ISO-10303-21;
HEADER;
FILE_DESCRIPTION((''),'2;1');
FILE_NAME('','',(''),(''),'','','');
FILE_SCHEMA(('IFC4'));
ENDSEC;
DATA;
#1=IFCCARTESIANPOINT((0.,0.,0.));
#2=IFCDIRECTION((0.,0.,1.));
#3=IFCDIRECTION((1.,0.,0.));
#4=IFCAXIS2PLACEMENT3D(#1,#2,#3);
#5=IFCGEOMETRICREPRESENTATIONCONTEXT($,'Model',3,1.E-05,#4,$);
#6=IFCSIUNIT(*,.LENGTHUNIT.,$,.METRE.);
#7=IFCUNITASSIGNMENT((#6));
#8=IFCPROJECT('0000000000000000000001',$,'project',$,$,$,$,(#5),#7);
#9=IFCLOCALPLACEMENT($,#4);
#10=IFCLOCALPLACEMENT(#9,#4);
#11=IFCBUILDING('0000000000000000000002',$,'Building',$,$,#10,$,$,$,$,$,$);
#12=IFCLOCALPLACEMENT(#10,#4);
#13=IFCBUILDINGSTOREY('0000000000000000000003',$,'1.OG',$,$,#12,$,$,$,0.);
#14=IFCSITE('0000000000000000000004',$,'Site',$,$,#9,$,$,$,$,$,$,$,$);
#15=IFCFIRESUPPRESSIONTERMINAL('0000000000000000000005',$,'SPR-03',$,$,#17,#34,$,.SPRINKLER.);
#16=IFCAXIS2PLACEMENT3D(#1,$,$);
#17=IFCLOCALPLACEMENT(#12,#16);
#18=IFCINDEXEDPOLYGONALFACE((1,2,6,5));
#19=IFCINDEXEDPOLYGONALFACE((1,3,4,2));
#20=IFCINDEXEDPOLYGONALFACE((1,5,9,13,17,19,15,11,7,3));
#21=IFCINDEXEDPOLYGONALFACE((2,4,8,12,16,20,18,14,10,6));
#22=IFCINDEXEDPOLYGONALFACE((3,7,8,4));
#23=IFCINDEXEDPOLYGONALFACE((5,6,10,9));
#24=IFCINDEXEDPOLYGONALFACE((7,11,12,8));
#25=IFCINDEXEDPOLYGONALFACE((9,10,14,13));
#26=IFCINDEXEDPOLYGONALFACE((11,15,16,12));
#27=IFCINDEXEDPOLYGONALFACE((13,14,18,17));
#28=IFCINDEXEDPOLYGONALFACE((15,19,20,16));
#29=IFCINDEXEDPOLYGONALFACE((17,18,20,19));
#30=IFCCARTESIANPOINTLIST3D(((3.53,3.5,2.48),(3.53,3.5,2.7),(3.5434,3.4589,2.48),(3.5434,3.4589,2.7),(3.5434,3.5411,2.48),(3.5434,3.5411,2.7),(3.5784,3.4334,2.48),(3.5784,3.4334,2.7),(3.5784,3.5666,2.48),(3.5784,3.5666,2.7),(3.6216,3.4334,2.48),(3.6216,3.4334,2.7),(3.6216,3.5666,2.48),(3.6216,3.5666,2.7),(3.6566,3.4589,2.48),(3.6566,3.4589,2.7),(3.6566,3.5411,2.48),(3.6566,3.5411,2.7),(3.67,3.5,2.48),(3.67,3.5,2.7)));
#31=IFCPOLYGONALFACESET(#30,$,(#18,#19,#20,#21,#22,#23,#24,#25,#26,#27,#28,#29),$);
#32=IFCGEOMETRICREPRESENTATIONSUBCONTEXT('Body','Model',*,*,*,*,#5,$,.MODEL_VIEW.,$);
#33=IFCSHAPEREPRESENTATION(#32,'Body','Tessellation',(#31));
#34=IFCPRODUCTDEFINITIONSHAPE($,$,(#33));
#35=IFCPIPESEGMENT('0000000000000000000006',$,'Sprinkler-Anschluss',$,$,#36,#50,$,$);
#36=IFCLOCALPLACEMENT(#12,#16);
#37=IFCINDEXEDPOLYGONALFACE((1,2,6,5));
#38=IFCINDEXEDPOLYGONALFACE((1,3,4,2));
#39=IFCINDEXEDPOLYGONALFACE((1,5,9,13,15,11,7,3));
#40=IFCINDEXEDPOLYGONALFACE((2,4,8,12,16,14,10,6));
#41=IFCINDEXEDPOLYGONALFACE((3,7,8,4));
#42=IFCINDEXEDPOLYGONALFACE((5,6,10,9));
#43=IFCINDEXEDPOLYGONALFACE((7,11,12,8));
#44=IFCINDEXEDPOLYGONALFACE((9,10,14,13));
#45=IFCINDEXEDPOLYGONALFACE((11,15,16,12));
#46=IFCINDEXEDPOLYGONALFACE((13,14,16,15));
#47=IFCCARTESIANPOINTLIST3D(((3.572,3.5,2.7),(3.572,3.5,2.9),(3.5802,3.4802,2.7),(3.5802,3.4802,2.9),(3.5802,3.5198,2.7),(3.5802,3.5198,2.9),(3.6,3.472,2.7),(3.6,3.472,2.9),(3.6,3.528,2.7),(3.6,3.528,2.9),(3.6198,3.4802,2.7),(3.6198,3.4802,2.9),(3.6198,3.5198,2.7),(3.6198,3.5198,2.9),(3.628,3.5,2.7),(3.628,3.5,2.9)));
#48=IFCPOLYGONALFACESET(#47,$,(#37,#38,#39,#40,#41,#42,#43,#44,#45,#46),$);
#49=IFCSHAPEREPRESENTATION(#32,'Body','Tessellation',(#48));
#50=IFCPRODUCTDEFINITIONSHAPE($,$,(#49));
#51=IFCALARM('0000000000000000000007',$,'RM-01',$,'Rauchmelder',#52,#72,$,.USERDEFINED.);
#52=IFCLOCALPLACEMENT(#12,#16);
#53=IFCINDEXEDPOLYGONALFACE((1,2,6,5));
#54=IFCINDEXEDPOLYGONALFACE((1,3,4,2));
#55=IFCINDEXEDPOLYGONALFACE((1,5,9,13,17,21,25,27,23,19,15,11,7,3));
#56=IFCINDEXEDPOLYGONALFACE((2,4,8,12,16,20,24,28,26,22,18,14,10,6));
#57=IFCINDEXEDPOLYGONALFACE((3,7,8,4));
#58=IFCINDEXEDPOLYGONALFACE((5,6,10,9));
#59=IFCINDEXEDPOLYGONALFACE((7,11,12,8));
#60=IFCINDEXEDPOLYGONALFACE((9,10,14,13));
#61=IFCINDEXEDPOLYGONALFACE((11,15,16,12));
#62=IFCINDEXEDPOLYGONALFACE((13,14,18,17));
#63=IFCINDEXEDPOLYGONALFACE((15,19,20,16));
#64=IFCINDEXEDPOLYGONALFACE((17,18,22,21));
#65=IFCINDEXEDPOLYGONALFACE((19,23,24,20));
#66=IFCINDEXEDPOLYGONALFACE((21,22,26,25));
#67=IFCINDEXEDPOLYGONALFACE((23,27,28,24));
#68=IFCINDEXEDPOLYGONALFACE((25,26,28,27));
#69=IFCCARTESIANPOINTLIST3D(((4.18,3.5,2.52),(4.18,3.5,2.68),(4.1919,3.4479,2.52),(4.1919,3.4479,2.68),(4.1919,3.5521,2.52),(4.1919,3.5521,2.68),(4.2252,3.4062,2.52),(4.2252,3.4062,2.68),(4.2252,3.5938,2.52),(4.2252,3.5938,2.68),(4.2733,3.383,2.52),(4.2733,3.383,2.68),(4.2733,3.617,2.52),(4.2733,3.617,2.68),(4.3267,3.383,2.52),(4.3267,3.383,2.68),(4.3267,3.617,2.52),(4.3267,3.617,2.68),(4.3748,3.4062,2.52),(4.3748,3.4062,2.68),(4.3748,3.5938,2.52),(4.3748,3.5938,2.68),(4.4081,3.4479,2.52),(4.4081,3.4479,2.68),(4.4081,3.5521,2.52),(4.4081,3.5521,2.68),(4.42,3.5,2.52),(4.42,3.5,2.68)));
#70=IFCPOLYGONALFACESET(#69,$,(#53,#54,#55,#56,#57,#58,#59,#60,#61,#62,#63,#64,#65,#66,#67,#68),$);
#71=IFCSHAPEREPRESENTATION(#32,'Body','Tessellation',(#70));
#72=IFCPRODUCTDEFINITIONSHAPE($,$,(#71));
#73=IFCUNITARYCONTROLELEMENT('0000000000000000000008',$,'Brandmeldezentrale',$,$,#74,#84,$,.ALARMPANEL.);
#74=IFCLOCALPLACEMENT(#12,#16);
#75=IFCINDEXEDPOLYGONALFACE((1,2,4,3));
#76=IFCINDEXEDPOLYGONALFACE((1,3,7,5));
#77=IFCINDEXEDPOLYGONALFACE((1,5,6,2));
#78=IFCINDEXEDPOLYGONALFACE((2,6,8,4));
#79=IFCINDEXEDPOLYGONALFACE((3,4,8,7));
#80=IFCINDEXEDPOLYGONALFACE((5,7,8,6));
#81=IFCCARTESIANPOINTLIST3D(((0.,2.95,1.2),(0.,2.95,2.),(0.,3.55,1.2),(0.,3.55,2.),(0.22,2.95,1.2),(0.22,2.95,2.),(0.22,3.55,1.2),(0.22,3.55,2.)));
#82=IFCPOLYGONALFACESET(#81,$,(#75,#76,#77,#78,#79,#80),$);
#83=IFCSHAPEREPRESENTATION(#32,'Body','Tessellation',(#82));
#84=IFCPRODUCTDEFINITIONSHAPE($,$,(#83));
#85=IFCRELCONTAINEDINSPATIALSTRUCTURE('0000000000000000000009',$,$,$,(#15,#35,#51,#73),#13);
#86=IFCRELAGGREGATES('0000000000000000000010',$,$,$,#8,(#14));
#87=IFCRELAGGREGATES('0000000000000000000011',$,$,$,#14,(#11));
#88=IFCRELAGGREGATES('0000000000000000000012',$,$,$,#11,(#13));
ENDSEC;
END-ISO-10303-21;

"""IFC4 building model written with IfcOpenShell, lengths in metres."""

from ifc_helpers import new_model, si_unit, frame, origin_with_axes, place, context, subcontext, project, spatial, polyline, outline, extrude, element, save


model = new_model("IFC4")

# Units and contexts
model_context = context("Model", 3, precision=1e-05, world=origin_with_axes())
body_context = subcontext(model_context, "Body", "Model", "MODEL_VIEW")
ifc_project = project(units=[si_unit("LENGTHUNIT", "METRE")], contexts=[model_context])

# Site, building, storey
site_placement = place(None, origin_with_axes())
site = spatial("IfcSite", under=ifc_project, at=site_placement, Name="Site")
building_placement = place(site_placement, origin_with_axes())
building = spatial("IfcBuilding", under=site, at=building_placement, Name="Building")
storey_placement = place(building_placement, origin_with_axes())
storey = spatial("IfcBuildingStorey", under=building, at=storey_placement, Name="1.OG", Elevation=0.0)

# Fire suppression terminal
fire_suppression_terminal_1_placement = place(storey_placement, origin_with_axes())
element("IfcFireSuppressionTerminal", 1, at=fire_suppression_terminal_1_placement, inside=storey, Name="SPR-03", PredefinedType="SPRINKLER", context=body_context, shape_type="SweptSolid", body=[
    extrude(outline(polyline([(0.07, 0.0, 0.0), (0.0566, 0.0411, 0.0), (0.0216, 0.0666, 0.0), (-0.0216, 0.0666, 0.0), (-0.0566, 0.0411, 0.0), (-0.07, 0.0, 0.0), (-0.0566, -0.0411, 0.0), (-0.0216, -0.0666, 0.0), (0.0216, -0.0666, 0.0), (0.0566, -0.0411, 0.0), (0.07, 0.0, 0.0)])), frame((3.6, 3.5, 2.48), z_axis=(0.0, 0.0, 1.0), x_axis=(1.0, 0.0, 0.0)), (0.0, 0.0, 1.0), 0.22),
])

# Pipe segment
pipe_segment_1_placement = place(storey_placement, origin_with_axes())
element("IfcPipeSegment", 2, at=pipe_segment_1_placement, inside=storey, Name="Sprinkler-Anschluss", context=body_context, shape_type="SweptSolid", body=[
    extrude(outline(polyline([(0.028, 0.0, 0.0), (0.0198, 0.0198, 0.0), (0.0, 0.028, 0.0), (-0.0198, 0.0198, 0.0), (-0.028, 0.0, 0.0), (-0.0198, -0.0198, 0.0), (0.0, -0.028, 0.0), (0.0198, -0.0198, 0.0), (0.028, 0.0, 0.0)])), frame((3.6, 3.5, 2.7), z_axis=(0.0, 0.0, 1.0), x_axis=(1.0, 0.0, 0.0)), (0.0, 0.0, 1.0), 0.2),
])

# Alarm
alarm_placement = place(storey_placement, origin_with_axes())
element("IfcAlarm", 3, at=alarm_placement, inside=storey, Name="RM-01", ObjectType="Rauchmelder", PredefinedType="USERDEFINED", context=body_context, shape_type="SweptSolid", body=[
    extrude(outline(polyline([(0.12, 0.0, 0.0), (0.1081, 0.0521, 0.0), (0.0748, 0.0938, 0.0), (0.0267, 0.117, 0.0), (-0.0267, 0.117, 0.0), (-0.0748, 0.0938, 0.0), (-0.1081, 0.0521, 0.0), (-0.12, 0.0, 0.0), (-0.1081, -0.0521, 0.0), (-0.0748, -0.0938, 0.0), (-0.0267, -0.117, 0.0), (0.0267, -0.117, 0.0), (0.0748, -0.0938, 0.0), (0.1081, -0.0521, 0.0), (0.12, 0.0, 0.0)])), frame((4.3, 3.5, 2.52), z_axis=(0.0, 0.0, 1.0), x_axis=(1.0, 0.0, 0.0)), (0.0, 0.0, 1.0), 0.16),
])

# Unitary control element
unitary_control_element_placement = place(storey_placement, origin_with_axes())
element("IfcUnitaryControlElement", 4, at=unitary_control_element_placement, inside=storey, Name="Brandmeldezentrale", PredefinedType="ALARMPANEL", context=body_context, shape_type="SweptSolid", body=[
    extrude(outline(polyline([(0.0, 2.95, 0.0), (0.22, 2.95, 0.0), (0.22, 3.55, 0.0), (0.0, 3.55, 0.0), (0.0, 2.95, 0.0)])), frame((0.0, 0.0, 1.2), z_axis=(0.0, 0.0, 1.0), x_axis=(1.0, 0.0, 0.0)), (0.0, 0.0, 1.0), 0.8),
])

save(model, "model.ifc")
